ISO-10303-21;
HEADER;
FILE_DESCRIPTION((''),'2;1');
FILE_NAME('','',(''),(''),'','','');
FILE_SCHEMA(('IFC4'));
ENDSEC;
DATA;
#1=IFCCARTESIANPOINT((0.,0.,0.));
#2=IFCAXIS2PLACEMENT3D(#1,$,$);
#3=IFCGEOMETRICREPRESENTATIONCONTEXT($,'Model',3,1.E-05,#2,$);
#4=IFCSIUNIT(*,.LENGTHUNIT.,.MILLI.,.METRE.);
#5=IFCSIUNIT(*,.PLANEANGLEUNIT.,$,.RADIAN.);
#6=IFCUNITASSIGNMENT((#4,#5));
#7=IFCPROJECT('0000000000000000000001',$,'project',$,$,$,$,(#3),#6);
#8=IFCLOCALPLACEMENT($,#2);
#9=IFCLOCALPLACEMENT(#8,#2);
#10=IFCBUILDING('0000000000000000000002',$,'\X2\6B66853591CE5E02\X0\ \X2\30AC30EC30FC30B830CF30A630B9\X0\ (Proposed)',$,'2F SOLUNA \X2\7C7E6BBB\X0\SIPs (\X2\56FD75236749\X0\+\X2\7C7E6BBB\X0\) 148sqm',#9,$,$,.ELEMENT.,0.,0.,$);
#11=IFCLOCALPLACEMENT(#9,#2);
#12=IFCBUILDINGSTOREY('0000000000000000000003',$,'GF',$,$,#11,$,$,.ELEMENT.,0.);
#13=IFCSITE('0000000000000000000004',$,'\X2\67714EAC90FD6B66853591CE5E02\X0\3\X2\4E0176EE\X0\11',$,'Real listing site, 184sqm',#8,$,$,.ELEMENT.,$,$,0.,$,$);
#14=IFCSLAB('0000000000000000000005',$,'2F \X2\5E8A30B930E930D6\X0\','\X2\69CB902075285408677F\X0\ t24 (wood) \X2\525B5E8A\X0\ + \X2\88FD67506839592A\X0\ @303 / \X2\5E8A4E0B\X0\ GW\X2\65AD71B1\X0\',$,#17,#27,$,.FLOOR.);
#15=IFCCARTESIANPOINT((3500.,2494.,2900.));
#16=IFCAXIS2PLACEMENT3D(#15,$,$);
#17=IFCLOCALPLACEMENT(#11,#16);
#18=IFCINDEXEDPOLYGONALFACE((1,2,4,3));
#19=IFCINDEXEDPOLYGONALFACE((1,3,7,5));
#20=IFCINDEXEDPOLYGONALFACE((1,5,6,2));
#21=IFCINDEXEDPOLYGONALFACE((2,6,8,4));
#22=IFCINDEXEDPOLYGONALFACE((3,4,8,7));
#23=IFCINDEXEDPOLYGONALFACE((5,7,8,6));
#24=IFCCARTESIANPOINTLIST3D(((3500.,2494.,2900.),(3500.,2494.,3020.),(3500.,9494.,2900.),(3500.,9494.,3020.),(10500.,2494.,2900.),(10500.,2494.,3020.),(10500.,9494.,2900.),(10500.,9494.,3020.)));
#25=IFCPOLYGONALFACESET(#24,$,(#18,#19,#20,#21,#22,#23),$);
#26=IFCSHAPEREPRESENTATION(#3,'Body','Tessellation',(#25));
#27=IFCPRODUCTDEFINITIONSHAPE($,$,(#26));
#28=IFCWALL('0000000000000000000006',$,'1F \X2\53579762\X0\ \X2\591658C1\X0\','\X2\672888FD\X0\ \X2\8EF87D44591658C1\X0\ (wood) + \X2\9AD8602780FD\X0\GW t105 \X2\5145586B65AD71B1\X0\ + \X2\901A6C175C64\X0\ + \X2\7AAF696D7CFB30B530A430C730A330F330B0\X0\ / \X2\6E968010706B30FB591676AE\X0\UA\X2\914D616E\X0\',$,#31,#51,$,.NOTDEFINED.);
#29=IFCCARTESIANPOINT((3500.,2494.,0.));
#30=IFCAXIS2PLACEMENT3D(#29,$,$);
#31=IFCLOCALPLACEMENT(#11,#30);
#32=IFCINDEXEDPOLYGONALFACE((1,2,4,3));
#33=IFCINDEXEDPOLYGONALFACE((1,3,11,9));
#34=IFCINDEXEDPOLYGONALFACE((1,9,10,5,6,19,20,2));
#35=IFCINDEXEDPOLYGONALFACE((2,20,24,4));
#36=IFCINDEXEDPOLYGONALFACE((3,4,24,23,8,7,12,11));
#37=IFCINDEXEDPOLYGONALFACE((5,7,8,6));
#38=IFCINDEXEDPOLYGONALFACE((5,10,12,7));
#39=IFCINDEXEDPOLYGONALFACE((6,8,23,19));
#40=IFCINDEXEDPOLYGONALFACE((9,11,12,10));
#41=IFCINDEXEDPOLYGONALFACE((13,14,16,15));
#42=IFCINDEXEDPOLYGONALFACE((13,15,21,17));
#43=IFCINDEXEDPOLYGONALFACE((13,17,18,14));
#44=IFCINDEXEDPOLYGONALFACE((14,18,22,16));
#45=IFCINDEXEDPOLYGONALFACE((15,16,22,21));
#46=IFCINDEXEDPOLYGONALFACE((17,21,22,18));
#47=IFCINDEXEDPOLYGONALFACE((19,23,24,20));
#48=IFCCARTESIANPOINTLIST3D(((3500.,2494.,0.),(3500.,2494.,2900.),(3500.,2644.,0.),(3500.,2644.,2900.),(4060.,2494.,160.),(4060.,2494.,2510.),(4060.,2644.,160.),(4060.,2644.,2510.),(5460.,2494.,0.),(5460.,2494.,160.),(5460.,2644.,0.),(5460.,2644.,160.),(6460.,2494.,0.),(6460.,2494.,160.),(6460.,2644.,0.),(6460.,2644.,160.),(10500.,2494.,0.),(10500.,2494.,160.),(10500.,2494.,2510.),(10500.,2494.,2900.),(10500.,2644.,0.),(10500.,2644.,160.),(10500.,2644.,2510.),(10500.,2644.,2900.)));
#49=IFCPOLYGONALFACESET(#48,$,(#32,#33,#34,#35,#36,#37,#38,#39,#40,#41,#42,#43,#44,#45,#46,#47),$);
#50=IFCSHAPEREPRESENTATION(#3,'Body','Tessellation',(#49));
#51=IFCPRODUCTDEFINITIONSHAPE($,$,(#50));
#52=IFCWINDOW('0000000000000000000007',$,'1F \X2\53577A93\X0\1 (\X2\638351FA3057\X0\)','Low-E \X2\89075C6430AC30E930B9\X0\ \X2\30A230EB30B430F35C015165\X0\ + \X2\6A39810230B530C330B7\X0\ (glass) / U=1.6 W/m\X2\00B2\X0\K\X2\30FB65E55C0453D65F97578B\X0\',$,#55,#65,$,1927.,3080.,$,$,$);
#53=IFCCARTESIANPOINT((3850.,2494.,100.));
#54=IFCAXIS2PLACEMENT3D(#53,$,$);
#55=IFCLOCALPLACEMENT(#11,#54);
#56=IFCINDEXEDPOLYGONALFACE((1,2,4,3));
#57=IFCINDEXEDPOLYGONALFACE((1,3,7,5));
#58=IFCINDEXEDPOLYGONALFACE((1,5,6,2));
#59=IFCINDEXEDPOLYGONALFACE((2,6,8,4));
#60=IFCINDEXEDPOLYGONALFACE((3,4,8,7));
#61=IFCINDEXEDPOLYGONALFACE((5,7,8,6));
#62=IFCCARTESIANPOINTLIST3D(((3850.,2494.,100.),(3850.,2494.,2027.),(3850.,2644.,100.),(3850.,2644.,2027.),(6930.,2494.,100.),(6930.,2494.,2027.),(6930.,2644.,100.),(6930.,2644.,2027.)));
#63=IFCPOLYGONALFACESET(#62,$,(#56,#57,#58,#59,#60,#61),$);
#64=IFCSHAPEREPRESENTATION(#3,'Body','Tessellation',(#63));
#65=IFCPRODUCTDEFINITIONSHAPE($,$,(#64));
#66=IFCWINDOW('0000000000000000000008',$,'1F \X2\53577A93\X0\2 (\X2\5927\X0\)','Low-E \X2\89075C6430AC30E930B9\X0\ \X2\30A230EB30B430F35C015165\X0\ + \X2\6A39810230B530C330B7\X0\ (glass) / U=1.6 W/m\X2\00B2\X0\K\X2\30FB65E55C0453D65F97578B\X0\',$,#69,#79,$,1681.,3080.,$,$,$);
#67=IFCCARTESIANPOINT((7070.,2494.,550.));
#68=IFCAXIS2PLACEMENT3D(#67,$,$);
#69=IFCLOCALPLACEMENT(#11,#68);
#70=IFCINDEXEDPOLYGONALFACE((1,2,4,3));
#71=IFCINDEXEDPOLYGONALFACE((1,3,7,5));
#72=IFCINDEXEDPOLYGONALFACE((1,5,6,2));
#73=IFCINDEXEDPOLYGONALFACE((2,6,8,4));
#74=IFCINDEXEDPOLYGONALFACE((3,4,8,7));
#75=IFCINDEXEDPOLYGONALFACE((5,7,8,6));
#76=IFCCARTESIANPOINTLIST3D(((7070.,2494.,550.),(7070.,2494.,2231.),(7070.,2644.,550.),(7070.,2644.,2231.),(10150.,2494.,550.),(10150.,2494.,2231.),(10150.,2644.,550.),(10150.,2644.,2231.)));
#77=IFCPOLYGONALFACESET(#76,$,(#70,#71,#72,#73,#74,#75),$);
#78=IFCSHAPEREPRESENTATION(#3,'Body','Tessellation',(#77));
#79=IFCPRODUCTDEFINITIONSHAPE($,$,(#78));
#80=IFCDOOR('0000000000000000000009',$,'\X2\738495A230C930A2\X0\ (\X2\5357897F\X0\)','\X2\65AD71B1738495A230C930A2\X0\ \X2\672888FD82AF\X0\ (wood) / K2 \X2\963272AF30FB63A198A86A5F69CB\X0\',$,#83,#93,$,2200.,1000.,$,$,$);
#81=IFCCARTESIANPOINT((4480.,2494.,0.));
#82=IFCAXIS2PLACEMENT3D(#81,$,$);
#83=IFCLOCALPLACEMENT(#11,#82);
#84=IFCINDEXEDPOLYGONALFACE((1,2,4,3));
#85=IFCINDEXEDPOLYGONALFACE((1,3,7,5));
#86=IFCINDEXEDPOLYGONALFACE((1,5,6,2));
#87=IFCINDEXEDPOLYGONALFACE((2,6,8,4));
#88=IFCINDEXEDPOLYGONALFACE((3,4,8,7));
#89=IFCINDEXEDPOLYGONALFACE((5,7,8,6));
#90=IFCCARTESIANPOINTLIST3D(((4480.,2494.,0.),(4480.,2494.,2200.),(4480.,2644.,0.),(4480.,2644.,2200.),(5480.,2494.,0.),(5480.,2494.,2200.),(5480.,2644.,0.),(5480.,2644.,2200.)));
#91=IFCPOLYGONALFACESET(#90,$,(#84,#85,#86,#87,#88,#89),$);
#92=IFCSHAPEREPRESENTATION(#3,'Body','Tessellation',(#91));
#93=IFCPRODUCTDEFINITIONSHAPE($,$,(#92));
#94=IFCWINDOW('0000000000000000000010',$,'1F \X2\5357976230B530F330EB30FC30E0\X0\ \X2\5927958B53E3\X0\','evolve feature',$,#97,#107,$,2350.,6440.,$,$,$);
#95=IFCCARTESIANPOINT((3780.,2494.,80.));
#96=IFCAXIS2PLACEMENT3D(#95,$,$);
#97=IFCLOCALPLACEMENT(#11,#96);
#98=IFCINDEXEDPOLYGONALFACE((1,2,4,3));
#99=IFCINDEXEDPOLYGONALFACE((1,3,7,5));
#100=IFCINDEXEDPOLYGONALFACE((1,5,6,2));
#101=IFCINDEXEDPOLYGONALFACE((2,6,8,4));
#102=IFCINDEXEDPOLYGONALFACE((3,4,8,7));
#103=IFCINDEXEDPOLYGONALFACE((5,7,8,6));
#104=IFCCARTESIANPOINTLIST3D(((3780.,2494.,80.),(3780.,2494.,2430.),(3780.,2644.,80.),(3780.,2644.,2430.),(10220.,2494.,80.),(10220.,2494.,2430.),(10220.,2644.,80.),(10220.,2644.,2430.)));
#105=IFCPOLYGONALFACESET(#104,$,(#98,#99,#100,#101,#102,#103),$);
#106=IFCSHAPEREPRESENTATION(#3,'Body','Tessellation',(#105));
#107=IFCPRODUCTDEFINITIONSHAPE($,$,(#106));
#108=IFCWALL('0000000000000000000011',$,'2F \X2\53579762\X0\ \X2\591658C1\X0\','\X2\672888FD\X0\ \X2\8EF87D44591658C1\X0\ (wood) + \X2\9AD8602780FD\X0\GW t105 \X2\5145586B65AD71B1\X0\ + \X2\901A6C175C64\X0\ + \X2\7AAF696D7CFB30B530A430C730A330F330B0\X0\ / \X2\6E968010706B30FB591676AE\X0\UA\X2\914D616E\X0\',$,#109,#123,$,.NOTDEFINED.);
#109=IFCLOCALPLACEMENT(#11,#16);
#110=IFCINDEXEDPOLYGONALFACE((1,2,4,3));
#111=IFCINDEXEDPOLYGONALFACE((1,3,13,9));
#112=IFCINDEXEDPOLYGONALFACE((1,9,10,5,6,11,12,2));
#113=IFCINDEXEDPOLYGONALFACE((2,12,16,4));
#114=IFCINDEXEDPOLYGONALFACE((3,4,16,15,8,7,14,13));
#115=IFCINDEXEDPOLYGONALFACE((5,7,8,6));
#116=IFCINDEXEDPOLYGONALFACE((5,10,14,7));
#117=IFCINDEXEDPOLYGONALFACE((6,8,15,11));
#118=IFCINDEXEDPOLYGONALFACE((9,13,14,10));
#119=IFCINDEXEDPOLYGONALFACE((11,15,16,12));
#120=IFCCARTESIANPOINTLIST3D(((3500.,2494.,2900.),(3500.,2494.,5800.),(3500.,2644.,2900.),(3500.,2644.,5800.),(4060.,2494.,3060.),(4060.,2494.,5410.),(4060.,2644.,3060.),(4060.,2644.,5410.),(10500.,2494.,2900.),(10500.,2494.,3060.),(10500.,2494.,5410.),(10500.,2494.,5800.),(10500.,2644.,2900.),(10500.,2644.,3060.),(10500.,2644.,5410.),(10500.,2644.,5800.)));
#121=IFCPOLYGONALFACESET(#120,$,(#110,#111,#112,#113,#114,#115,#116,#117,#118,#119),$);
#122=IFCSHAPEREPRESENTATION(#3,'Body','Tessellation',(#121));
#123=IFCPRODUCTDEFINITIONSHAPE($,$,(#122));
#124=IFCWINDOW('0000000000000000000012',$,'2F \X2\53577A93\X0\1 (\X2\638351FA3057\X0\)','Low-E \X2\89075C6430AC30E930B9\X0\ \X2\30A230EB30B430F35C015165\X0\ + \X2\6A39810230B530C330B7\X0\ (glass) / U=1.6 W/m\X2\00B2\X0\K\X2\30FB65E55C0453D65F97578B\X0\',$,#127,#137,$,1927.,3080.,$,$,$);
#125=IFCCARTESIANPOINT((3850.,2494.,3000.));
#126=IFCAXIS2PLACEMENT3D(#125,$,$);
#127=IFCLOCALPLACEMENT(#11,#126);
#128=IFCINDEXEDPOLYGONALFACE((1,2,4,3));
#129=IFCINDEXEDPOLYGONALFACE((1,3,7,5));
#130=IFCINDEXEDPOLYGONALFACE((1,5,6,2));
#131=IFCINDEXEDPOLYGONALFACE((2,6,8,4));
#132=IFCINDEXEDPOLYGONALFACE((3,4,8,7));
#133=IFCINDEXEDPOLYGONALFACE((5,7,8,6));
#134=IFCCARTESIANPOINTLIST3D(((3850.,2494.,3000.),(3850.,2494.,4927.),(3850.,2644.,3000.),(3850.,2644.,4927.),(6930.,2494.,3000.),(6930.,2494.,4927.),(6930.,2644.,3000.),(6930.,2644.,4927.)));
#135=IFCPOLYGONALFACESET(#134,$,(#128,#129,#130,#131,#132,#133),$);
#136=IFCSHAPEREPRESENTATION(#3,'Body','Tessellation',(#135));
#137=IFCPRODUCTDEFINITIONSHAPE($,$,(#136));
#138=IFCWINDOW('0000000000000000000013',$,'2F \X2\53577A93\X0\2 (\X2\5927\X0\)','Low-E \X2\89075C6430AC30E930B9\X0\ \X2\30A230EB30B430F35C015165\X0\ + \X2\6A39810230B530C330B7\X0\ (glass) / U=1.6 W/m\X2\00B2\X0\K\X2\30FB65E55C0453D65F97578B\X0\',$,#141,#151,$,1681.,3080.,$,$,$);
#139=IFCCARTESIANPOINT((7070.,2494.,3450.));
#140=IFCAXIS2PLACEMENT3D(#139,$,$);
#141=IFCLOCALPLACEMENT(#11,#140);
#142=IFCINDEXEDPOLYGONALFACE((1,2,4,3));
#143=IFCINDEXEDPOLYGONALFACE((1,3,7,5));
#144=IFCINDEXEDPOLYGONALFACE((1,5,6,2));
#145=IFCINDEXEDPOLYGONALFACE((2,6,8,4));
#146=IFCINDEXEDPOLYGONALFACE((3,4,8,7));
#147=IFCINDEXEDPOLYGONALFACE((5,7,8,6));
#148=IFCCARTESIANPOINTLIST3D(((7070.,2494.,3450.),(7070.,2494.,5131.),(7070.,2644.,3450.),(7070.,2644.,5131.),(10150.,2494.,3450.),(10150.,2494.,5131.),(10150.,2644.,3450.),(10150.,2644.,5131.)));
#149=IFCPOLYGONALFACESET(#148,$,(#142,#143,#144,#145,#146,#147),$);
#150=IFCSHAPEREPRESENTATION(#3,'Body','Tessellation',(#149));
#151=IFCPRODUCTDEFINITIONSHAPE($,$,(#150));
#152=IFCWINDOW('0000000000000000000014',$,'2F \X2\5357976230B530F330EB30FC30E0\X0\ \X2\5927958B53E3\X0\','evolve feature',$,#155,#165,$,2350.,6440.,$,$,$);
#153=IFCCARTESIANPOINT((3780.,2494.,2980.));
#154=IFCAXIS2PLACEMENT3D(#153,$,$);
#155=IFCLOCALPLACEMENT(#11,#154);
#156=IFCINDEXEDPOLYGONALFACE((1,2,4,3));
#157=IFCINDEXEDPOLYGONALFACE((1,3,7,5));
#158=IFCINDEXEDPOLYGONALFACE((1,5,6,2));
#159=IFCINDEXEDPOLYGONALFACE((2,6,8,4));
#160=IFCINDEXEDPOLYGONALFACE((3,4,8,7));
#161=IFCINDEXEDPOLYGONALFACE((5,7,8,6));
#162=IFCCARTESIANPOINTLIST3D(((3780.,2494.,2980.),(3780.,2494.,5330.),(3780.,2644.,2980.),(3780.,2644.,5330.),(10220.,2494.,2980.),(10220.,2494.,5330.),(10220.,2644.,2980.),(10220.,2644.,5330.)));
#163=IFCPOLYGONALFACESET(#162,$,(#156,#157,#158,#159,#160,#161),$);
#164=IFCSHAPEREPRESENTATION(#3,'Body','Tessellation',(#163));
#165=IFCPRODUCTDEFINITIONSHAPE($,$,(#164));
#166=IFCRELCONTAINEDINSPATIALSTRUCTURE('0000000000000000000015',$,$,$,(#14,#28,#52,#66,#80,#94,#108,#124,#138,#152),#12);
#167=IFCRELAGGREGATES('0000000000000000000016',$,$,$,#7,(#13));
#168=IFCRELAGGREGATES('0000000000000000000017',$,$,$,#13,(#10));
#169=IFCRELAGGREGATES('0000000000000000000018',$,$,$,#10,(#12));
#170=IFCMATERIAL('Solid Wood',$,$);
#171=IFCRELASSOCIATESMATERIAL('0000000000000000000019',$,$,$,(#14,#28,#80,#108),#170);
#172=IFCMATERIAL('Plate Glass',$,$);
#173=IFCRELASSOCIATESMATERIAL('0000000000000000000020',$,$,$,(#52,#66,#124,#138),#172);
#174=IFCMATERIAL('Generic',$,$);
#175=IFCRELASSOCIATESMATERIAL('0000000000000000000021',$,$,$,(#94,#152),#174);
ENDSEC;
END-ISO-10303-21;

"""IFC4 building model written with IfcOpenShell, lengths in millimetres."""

from ifc_helpers import new_model, si_unit, frame, frame_2d, origin, place, context, project, spatial, rectangle, extrude, material, element, fill, save


model = new_model("IFC4")

# Units and contexts
model_context = context("Model", 3, precision=1e-05, world=origin())
ifc_project = project(units=[si_unit("LENGTHUNIT", "METRE", prefix="MILLI"), si_unit("PLANEANGLEUNIT", "RADIAN")], contexts=[model_context])

# Site, building, storey
site_placement = place(None, origin())
site = spatial("IfcSite", under=ifc_project, at=site_placement, Name="東京都武蔵野市3丁目11", ObjectType="Real listing site, 184sqm", CompositionType="ELEMENT", RefElevation=0.0)
building_placement = place(site_placement, origin())
building = spatial("IfcBuilding", under=site, at=building_placement, Name="武蔵野市 ガレージハウス (Proposed)", ObjectType="2F SOLUNA 籾殻SIPs (国産杉+籾殻) 148sqm", CompositionType="ELEMENT", ElevationOfRefHeight=0.0, ElevationOfTerrain=0.0)
storey_placement = place(building_placement, origin())
storey = spatial("IfcBuildingStorey", under=building, at=storey_placement, Name="GF", CompositionType="ELEMENT", Elevation=0.0)

# Slab
ifc_material_1 = material(Name="Solid Wood")
slab_1_placement = place(storey_placement, frame((3500.0, 2494.0, 2900.0)))
element("IfcSlab", 1, at=slab_1_placement, inside=storey, material=ifc_material_1, Name="2F 床スラブ", Description="構造用合板 t24 (wood) 剛床 + 製材根太 @303 / 床下 GW断熱", PredefinedType="FLOOR", context=model_context, shape_type="SweptSolid", body=[
    extrude(rectangle(XDim=7000.0, YDim=7000.0, at=frame_2d((3500.0, 3500.0))), frame((3500.0, 2494.0, 2900.0)), (0.0, 0.0, 1.0), 120.0),
])
ifc_material_2 = material(Name="Generic")

# Wall, openings, windows, door
wall_1_placement = place(storey_placement, frame((3500.0, 2494.0, 0.0)))
wall_1 = element("IfcWall", 2, at=wall_1_placement, inside=storey, material=ifc_material_1, Name="1F 南面 外壁", Description="木製 軸組外壁 (wood) + 高性能GW t105 充填断熱 + 通気層 + 窯業系サイディング / 準耐火・外皮UA配慮", PredefinedType="NOTDEFINED", context=model_context, shape_type="SweptSolid", body=[
    extrude(rectangle(XDim=7000.0, YDim=150.0, at=frame_2d((3500.0, 75.0))), frame((3500.0, 2494.0, 0.0)), (0.0, 0.0, 1.0), 2900.0),
])
opening_1_placement = place(storey_placement, frame((3850.0, 2494.0, 100.0)))
opening_1 = element("IfcOpeningElement", 3, at=opening_1_placement, cuts=wall_1, PredefinedType="NOTDEFINED", context=model_context, shape_type="SweptSolid", body=[
    extrude(rectangle(XDim=3080.0, YDim=150.0, at=frame_2d((1540.0, 75.0))), frame((3850.0, 2494.0, 100.0)), (0.0, 0.0, 1.0), 1927.0),
])
opening_2_placement = place(storey_placement, frame((7070.0, 2494.0, 550.0)))
opening_2 = element("IfcOpeningElement", 4, at=opening_2_placement, cuts=wall_1, PredefinedType="NOTDEFINED", context=model_context, shape_type="SweptSolid", body=[
    extrude(rectangle(XDim=3080.0, YDim=150.0, at=frame_2d((1540.0, 75.0))), frame((7070.0, 2494.0, 550.0)), (0.0, 0.0, 1.0), 1681.0),
])
opening_3_placement = place(storey_placement, frame((4480.0, 2494.0, 0.0)))
opening_3 = element("IfcOpeningElement", 5, at=opening_3_placement, cuts=wall_1, PredefinedType="NOTDEFINED", context=model_context, shape_type="SweptSolid", body=[
    extrude(rectangle(XDim=1000.0, YDim=150.0, at=frame_2d((500.0, 75.0))), frame((4480.0, 2494.0, 0.0)), (0.0, 0.0, 1.0), 2200.0),
])
opening_4_placement = place(storey_placement, frame((3780.0, 2494.0, 80.0)))
opening_4 = element("IfcOpeningElement", 6, at=opening_4_placement, cuts=wall_1, PredefinedType="NOTDEFINED", context=model_context, shape_type="SweptSolid", body=[
    extrude(rectangle(XDim=6440.0, YDim=150.0, at=frame_2d((3220.0, 75.0))), frame((3780.0, 2494.0, 80.0)), (0.0, 0.0, 1.0), 2350.0),
])
ifc_material_3 = material(Name="Plate Glass")
window_1_placement = place(storey_placement, frame((3850.0, 2494.0, 100.0)))
window_1 = element("IfcWindow", 7, at=window_1_placement, inside=storey, material=ifc_material_3, Name="1F 南窓1 (掃出し)", Description="Low-E 複層ガラス アルゴン封入 + 樹脂サッシ (glass) / U=1.6 W/m²K・日射取得型", OverallHeight=1927.0, OverallWidth=3080.0, context=model_context, shape_type="SweptSolid", body=[
    extrude(rectangle(XDim=3080.0, YDim=150.0, at=frame_2d((1540.0, 75.0))), frame((3850.0, 2494.0, 100.0)), (0.0, 0.0, 1.0), 1927.0),
])
fill(opening_1, window_1)
window_2_placement = place(storey_placement, frame((7070.0, 2494.0, 550.0)))
window_2 = element("IfcWindow", 8, at=window_2_placement, inside=storey, material=ifc_material_3, Name="1F 南窓2 (大)", Description="Low-E 複層ガラス アルゴン封入 + 樹脂サッシ (glass) / U=1.6 W/m²K・日射取得型", OverallHeight=1681.0, OverallWidth=3080.0, context=model_context, shape_type="SweptSolid", body=[
    extrude(rectangle(XDim=3080.0, YDim=150.0, at=frame_2d((1540.0, 75.0))), frame((7070.0, 2494.0, 550.0)), (0.0, 0.0, 1.0), 1681.0),
])
fill(opening_2, window_2)
door_placement = place(storey_placement, frame((4480.0, 2494.0, 0.0)))
door = element("IfcDoor", 9, at=door_placement, inside=storey, material=ifc_material_1, Name="玄関ドア (南西)", Description="断熱玄関ドア 木製芯 (wood) / K2 防犯・採風機構", OverallHeight=2200.0, OverallWidth=1000.0, context=model_context, shape_type="SweptSolid", body=[
    extrude(rectangle(XDim=1000.0, YDim=150.0, at=frame_2d((500.0, 75.0))), frame((4480.0, 2494.0, 0.0)), (0.0, 0.0, 1.0), 2200.0),
])
fill(opening_3, door)
window_3_placement = place(storey_placement, frame((3780.0, 2494.0, 80.0)))
window_3 = element("IfcWindow", 10, at=window_3_placement, inside=storey, material=ifc_material_2, Name="1F 南面サンルーム 大開口", Description="evolve feature", OverallHeight=2350.0, OverallWidth=6440.0, context=model_context, shape_type="SweptSolid", body=[
    extrude(rectangle(XDim=6440.0, YDim=150.0, at=frame_2d((3220.0, 75.0))), frame((3780.0, 2494.0, 80.0)), (0.0, 0.0, 1.0), 2350.0),
])
fill(opening_4, window_3)

# Wall, openings, windows
wall_2_placement = place(storey_placement, frame((3500.0, 2494.0, 2900.0)))
wall_2 = element("IfcWall", 11, at=wall_2_placement, inside=storey, material=ifc_material_1, Name="2F 南面 外壁", Description="木製 軸組外壁 (wood) + 高性能GW t105 充填断熱 + 通気層 + 窯業系サイディング / 準耐火・外皮UA配慮", PredefinedType="NOTDEFINED", context=model_context, shape_type="SweptSolid", body=[
    extrude(rectangle(XDim=7000.0, YDim=150.0, at=frame_2d((3500.0, 75.0))), frame((3500.0, 2494.0, 2900.0)), (0.0, 0.0, 1.0), 2900.0),
])
opening_5_placement = place(storey_placement, frame((3850.0, 2494.0, 3000.0)))
opening_5 = element("IfcOpeningElement", 12, at=opening_5_placement, cuts=wall_2, PredefinedType="NOTDEFINED", context=model_context, shape_type="SweptSolid", body=[
    extrude(rectangle(XDim=3080.0, YDim=150.0, at=frame_2d((1540.0, 75.0))), frame((3850.0, 2494.0, 3000.0)), (0.0, 0.0, 1.0), 1927.0),
])
opening_6_placement = place(storey_placement, frame((7070.0, 2494.0, 3450.0)))
opening_6 = element("IfcOpeningElement", 13, at=opening_6_placement, cuts=wall_2, PredefinedType="NOTDEFINED", context=model_context, shape_type="SweptSolid", body=[
    extrude(rectangle(XDim=3080.0, YDim=150.0, at=frame_2d((1540.0, 75.0))), frame((7070.0, 2494.0, 3450.0)), (0.0, 0.0, 1.0), 1681.0),
])
opening_7_placement = place(storey_placement, frame((3780.0, 2494.0, 2980.0)))
opening_7 = element("IfcOpeningElement", 14, at=opening_7_placement, cuts=wall_2, PredefinedType="NOTDEFINED", context=model_context, shape_type="SweptSolid", body=[
    extrude(rectangle(XDim=6440.0, YDim=150.0, at=frame_2d((3220.0, 75.0))), frame((3780.0, 2494.0, 2980.0)), (0.0, 0.0, 1.0), 2350.0),
])
window_4_placement = place(storey_placement, frame((3850.0, 2494.0, 3000.0)))
window_4 = element("IfcWindow", 15, at=window_4_placement, inside=storey, material=ifc_material_3, Name="2F 南窓1 (掃出し)", Description="Low-E 複層ガラス アルゴン封入 + 樹脂サッシ (glass) / U=1.6 W/m²K・日射取得型", OverallHeight=1927.0, OverallWidth=3080.0, context=model_context, shape_type="SweptSolid", body=[
    extrude(rectangle(XDim=3080.0, YDim=150.0, at=frame_2d((1540.0, 75.0))), frame((3850.0, 2494.0, 3000.0)), (0.0, 0.0, 1.0), 1927.0),
])
fill(opening_5, window_4)
window_5_placement = place(storey_placement, frame((7070.0, 2494.0, 3450.0)))
window_5 = element("IfcWindow", 16, at=window_5_placement, inside=storey, material=ifc_material_3, Name="2F 南窓2 (大)", Description="Low-E 複層ガラス アルゴン封入 + 樹脂サッシ (glass) / U=1.6 W/m²K・日射取得型", OverallHeight=1681.0, OverallWidth=3080.0, context=model_context, shape_type="SweptSolid", body=[
    extrude(rectangle(XDim=3080.0, YDim=150.0, at=frame_2d((1540.0, 75.0))), frame((7070.0, 2494.0, 3450.0)), (0.0, 0.0, 1.0), 1681.0),
])
fill(opening_6, window_5)
window_6_placement = place(storey_placement, frame((3780.0, 2494.0, 2980.0)))
window_6 = element("IfcWindow", 17, at=window_6_placement, inside=storey, material=ifc_material_2, Name="2F 南面サンルーム 大開口", Description="evolve feature", OverallHeight=2350.0, OverallWidth=6440.0, context=model_context, shape_type="SweptSolid", body=[
    extrude(rectangle(XDim=6440.0, YDim=150.0, at=frame_2d((3220.0, 75.0))), frame((3780.0, 2494.0, 2980.0)), (0.0, 0.0, 1.0), 2350.0),
])
fill(opening_7, window_6)

save(model, "model.ifc")
